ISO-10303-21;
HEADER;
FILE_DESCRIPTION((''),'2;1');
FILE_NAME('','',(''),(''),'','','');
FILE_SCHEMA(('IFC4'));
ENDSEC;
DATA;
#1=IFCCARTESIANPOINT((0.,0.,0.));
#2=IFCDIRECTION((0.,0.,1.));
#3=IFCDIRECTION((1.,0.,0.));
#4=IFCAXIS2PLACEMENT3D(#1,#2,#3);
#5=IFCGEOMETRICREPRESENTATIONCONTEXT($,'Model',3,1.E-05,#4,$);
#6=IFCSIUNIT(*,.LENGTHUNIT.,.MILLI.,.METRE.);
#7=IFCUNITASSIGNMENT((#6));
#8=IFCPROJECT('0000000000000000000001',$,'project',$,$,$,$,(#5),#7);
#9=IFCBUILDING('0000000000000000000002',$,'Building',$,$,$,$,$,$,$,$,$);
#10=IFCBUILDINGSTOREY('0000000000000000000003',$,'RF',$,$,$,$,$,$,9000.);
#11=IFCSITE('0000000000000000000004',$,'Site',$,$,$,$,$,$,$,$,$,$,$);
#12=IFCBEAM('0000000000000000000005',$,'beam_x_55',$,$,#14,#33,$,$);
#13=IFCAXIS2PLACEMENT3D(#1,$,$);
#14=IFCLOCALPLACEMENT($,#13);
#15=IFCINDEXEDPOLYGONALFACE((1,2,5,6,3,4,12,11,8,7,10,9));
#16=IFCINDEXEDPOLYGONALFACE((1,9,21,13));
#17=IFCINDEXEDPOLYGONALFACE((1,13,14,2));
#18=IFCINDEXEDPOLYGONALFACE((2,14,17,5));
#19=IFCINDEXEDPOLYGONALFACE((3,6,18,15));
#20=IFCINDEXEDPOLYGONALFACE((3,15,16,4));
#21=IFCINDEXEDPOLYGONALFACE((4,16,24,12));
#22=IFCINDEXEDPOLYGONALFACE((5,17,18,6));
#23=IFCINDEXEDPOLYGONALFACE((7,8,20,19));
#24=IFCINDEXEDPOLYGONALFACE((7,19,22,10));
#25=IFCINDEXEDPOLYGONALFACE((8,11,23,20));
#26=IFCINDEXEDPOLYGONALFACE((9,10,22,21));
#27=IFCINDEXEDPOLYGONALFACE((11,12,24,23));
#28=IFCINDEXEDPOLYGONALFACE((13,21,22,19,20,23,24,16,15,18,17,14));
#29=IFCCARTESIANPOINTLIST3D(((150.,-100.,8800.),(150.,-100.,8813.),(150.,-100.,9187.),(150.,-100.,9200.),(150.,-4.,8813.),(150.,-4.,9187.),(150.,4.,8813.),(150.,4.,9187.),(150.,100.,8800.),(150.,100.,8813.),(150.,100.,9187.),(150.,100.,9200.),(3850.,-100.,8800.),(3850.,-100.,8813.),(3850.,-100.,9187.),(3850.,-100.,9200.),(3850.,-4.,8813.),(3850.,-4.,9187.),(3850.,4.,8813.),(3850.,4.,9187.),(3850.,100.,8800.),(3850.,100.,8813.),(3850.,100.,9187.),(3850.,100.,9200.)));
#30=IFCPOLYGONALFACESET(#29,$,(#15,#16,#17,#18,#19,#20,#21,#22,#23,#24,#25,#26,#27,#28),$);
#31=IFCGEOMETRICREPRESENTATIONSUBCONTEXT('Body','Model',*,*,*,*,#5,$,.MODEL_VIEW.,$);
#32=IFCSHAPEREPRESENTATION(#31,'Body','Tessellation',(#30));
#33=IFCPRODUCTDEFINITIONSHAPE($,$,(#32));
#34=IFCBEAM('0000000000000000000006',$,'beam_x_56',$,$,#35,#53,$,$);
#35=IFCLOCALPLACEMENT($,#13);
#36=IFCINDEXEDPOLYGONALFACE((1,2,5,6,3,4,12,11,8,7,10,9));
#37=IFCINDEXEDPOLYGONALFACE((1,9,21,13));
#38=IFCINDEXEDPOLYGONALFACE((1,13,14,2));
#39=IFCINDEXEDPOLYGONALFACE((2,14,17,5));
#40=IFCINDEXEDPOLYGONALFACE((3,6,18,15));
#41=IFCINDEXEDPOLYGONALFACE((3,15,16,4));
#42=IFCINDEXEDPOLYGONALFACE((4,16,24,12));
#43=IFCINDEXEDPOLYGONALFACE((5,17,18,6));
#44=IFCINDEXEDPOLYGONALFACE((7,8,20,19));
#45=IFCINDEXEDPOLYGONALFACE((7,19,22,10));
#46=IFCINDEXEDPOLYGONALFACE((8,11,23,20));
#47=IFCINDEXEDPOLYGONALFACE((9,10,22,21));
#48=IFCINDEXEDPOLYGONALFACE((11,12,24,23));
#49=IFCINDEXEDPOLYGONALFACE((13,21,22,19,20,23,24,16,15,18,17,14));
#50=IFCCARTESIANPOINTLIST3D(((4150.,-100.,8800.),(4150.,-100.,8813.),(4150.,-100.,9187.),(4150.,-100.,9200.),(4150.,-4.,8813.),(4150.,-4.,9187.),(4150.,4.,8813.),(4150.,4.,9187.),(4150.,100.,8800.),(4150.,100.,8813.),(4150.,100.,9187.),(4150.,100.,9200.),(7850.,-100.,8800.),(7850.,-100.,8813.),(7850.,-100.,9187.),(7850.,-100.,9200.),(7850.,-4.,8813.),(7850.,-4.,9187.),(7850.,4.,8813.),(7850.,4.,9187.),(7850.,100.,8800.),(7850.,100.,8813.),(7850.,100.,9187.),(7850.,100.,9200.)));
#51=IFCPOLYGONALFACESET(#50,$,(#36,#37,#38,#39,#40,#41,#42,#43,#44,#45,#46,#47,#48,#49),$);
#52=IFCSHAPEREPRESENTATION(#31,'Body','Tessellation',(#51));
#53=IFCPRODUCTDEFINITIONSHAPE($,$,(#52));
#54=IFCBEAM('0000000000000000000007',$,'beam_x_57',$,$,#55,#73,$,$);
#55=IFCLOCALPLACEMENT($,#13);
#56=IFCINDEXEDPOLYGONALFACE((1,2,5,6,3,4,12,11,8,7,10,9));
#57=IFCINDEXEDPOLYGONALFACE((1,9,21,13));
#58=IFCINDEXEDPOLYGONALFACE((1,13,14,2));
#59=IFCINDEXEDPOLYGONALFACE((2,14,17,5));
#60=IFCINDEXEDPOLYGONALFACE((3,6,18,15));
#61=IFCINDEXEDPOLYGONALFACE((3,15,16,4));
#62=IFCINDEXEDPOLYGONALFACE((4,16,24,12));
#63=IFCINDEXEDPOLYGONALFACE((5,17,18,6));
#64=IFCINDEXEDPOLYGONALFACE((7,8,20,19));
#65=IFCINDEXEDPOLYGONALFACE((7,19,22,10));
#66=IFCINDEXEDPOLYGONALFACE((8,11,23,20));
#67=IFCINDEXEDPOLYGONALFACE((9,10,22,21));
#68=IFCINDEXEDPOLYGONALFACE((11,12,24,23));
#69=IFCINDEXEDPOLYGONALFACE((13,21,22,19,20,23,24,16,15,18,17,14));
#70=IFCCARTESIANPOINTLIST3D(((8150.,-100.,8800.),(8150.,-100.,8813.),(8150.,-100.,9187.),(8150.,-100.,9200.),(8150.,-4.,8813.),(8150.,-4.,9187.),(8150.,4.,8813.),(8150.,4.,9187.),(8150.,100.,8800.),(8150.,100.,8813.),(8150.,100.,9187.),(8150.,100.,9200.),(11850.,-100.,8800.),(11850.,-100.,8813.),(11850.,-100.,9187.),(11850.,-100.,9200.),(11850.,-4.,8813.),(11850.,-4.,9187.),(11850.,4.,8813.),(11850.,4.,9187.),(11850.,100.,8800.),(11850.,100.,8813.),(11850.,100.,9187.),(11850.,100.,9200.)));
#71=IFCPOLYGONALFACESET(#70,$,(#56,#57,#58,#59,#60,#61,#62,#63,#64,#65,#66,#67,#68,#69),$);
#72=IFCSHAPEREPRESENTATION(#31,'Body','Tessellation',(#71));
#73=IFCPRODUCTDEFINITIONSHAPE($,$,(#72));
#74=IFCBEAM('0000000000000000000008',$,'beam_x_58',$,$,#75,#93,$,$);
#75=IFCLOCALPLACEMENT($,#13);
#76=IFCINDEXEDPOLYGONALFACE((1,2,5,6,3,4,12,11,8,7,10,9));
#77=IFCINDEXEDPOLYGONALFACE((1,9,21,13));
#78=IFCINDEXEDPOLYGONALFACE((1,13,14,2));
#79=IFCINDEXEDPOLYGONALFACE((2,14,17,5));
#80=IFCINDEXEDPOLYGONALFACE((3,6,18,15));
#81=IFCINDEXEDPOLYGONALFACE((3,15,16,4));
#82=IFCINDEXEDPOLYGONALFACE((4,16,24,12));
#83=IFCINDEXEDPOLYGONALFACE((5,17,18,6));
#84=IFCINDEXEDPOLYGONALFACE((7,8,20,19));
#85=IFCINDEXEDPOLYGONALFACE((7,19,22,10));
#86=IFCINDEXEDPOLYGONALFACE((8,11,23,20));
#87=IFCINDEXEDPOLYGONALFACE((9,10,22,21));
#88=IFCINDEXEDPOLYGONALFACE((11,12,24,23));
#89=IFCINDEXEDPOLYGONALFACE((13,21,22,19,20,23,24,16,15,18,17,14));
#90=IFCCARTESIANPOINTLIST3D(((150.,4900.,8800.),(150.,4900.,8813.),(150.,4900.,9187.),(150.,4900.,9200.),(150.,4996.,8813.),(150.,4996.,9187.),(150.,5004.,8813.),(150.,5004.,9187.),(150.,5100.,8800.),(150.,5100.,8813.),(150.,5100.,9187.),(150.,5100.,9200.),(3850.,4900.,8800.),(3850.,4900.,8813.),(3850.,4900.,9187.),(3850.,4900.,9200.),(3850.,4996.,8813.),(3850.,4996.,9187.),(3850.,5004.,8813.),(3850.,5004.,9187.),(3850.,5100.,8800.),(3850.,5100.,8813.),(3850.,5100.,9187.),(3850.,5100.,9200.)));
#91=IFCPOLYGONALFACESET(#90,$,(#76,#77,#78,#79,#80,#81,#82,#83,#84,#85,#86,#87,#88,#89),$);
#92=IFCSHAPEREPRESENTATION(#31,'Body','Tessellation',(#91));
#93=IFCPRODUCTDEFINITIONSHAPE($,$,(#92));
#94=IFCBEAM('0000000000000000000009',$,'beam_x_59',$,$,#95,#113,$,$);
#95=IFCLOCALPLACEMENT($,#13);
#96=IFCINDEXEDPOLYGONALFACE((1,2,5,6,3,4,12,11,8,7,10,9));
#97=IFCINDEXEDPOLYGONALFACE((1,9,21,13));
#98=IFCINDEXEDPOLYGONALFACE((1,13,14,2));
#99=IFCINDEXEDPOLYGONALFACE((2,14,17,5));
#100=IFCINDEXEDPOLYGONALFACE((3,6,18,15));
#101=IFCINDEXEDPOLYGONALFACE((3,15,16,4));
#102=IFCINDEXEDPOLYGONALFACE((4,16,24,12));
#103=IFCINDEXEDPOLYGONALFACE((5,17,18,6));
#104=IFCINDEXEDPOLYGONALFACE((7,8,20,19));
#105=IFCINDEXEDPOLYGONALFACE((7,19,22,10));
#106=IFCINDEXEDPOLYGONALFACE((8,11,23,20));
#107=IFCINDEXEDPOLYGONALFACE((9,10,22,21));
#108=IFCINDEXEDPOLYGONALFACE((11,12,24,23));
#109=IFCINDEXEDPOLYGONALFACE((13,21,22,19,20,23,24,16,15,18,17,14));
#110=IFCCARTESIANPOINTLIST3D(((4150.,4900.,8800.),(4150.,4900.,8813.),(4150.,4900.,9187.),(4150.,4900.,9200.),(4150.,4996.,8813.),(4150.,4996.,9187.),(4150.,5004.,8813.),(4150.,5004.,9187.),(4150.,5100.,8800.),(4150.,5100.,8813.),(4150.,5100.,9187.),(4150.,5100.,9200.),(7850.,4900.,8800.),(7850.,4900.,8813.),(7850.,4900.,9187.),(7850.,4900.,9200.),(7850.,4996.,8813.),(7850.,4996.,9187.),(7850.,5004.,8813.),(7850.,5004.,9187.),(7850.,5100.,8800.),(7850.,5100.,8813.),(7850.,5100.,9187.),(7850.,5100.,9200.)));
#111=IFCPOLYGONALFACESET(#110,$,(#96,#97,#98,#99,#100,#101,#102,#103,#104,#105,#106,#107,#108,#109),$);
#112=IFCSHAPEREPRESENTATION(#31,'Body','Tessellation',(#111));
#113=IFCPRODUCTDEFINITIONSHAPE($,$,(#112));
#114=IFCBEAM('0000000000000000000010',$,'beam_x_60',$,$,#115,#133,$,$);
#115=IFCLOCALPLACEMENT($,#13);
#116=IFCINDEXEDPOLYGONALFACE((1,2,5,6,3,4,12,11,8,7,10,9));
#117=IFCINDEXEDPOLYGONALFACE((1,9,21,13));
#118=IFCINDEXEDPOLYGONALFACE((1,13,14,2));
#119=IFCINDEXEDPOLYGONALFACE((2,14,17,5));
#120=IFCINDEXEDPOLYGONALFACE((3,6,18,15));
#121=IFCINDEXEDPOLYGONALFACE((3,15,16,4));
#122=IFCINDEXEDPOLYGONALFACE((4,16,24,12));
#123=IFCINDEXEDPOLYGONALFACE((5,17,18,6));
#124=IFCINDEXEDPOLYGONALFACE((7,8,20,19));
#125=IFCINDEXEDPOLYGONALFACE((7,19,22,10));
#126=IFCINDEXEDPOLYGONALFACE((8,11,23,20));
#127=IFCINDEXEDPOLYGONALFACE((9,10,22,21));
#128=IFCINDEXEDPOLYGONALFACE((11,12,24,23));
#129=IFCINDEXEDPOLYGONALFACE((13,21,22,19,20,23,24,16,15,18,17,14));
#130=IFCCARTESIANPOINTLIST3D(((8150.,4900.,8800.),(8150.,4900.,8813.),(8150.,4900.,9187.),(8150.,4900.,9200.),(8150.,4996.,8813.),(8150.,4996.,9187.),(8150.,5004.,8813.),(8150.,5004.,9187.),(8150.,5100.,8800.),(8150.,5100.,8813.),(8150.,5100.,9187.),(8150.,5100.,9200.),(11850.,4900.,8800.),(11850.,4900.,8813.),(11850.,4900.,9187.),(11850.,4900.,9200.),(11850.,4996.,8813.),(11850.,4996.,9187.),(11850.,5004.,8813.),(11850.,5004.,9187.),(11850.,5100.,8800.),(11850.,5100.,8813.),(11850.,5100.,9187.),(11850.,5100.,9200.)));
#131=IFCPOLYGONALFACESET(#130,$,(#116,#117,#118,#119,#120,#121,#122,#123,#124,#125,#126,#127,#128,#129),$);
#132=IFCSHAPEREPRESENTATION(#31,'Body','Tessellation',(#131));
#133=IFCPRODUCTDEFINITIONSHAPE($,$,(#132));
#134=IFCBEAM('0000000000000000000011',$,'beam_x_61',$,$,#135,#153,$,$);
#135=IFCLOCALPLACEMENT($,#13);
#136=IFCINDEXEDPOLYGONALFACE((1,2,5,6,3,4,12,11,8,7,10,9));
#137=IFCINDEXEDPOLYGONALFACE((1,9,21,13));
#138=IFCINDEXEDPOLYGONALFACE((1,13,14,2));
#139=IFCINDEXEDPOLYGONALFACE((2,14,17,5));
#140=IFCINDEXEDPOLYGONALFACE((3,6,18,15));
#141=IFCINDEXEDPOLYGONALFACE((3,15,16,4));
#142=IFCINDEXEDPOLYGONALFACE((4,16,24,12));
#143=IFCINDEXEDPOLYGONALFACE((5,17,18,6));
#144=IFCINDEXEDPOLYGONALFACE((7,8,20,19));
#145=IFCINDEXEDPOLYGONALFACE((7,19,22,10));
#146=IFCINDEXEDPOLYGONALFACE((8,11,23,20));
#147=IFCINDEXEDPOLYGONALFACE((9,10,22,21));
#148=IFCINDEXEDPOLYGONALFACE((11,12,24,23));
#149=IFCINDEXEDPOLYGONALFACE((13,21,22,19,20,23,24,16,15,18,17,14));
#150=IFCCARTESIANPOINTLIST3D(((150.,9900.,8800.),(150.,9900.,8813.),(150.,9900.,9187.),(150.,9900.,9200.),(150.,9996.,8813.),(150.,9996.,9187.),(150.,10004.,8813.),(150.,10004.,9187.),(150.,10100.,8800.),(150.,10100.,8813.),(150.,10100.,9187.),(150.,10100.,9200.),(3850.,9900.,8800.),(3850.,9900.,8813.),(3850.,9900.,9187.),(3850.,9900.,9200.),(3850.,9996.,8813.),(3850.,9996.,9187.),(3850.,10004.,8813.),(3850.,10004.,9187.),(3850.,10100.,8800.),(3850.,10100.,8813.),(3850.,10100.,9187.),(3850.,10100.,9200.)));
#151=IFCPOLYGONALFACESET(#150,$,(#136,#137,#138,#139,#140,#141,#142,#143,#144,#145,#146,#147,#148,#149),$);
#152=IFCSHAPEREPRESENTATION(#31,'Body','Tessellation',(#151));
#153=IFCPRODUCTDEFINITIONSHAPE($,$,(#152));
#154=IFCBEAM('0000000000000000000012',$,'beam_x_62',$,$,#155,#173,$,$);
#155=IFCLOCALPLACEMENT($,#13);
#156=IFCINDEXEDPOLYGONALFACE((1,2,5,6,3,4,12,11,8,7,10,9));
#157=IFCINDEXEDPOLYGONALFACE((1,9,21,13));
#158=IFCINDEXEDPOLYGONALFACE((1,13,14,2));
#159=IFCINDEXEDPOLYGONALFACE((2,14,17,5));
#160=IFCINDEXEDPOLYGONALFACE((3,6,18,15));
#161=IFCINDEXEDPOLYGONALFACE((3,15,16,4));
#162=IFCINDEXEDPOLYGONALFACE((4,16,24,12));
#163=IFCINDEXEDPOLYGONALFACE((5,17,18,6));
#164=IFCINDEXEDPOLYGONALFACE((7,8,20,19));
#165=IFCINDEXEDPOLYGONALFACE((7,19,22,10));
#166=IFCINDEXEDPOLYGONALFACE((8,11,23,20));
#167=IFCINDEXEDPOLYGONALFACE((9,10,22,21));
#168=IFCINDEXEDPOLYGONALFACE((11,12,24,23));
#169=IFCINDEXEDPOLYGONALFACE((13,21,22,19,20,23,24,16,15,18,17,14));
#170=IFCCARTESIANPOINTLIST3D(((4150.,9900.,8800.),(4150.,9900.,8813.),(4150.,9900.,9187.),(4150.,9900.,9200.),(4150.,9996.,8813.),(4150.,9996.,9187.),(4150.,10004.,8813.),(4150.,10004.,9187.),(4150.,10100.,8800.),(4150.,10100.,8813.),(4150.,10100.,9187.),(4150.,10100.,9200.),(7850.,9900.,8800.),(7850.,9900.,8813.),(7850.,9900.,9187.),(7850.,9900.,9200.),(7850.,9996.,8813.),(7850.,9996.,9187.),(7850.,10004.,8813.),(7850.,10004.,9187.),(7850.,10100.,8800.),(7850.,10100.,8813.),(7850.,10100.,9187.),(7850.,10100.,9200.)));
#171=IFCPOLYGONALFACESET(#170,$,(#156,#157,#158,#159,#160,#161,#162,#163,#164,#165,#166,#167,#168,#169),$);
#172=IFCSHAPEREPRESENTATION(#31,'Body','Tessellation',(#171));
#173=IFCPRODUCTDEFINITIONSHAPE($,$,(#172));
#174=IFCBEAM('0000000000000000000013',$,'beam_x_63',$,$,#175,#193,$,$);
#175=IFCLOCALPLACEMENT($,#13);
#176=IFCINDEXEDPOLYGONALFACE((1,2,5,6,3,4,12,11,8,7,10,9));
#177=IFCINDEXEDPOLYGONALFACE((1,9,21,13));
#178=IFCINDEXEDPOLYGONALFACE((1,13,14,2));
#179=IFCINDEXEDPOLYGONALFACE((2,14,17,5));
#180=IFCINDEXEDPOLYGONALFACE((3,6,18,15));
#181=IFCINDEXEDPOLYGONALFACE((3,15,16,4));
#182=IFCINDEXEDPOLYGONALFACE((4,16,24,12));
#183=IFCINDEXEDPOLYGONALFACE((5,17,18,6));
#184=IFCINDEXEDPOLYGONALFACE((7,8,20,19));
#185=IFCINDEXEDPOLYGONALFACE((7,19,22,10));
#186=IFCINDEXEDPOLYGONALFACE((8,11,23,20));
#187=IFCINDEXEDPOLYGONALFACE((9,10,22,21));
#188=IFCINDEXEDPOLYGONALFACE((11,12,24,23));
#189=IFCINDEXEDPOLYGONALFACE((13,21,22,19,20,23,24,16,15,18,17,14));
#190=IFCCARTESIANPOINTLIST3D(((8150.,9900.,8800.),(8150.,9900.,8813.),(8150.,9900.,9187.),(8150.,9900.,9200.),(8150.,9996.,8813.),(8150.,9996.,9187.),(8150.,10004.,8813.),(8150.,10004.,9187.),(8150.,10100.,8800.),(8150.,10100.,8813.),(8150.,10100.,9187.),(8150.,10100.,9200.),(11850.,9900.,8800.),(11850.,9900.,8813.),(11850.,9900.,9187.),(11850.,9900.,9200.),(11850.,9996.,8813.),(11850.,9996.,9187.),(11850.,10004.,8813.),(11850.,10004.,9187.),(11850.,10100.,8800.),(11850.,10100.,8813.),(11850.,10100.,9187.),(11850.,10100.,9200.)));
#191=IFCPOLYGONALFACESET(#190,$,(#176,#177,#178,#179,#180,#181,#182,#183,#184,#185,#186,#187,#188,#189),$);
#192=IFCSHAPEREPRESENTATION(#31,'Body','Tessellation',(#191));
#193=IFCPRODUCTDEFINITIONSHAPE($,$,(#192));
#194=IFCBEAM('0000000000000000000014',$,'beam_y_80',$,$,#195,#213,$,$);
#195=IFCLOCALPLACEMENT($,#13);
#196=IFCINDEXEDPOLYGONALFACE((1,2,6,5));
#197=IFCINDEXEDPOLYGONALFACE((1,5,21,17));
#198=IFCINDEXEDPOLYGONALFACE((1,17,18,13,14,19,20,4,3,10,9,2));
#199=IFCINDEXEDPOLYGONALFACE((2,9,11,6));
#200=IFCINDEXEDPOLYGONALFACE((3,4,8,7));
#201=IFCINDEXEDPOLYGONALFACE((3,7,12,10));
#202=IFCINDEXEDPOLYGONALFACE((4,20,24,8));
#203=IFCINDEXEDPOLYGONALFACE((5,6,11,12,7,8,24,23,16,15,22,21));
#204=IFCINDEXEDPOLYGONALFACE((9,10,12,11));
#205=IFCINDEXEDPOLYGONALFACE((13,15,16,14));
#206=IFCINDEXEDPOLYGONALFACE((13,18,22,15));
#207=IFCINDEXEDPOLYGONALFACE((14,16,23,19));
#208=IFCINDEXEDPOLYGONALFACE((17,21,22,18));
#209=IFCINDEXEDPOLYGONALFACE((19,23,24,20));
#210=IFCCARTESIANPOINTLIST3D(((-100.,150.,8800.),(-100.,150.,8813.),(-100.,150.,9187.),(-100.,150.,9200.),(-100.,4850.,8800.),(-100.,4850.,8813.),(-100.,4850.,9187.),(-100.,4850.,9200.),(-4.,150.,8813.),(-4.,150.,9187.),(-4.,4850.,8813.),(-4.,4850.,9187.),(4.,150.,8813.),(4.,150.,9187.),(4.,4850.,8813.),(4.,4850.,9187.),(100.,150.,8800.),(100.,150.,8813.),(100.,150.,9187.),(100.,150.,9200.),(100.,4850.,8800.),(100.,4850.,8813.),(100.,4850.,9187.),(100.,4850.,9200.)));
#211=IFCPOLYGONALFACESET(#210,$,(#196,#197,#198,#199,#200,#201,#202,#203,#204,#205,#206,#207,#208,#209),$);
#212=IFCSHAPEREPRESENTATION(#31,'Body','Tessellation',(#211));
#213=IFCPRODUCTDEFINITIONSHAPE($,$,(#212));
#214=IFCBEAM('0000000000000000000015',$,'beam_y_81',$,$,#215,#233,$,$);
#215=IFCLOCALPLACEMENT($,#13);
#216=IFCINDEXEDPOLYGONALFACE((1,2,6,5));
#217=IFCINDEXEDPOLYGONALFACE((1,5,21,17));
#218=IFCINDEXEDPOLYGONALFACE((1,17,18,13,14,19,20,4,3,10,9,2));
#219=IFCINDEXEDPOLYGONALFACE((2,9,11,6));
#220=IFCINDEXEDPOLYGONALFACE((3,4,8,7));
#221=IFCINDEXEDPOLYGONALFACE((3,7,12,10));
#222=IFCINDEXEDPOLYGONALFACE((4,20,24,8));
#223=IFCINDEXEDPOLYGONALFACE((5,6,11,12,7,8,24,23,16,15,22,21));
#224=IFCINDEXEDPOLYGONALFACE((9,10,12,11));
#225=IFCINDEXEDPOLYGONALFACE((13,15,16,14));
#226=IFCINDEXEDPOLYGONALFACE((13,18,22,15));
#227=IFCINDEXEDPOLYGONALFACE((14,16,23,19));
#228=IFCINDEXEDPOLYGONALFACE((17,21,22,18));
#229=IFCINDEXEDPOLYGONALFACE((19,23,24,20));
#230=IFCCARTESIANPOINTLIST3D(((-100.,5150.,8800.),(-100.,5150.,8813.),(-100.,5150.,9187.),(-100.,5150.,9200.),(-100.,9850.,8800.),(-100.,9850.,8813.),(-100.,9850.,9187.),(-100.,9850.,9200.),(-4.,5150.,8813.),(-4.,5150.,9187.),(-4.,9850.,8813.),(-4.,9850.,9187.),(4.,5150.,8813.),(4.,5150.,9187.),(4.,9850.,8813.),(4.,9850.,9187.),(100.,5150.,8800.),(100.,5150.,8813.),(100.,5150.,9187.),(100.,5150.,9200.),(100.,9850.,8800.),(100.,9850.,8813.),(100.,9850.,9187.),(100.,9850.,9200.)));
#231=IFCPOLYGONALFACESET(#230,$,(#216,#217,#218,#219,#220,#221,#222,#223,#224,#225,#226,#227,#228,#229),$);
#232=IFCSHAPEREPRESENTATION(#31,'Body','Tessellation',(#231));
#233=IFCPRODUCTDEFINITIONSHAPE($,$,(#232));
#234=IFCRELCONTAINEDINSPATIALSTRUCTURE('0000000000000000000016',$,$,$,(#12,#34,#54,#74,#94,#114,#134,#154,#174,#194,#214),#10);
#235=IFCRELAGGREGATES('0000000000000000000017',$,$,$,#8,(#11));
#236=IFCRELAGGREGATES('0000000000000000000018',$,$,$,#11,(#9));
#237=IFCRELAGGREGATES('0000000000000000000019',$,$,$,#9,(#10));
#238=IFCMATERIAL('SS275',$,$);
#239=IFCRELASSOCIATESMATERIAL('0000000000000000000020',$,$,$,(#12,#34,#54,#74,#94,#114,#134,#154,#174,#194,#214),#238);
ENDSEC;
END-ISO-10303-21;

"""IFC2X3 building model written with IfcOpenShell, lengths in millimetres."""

from ifc_helpers import new_model, si_unit, frame, origin, origin_with_axes, origin_2d_with_axis, place, context, subcontext, project, spatial, i_section, extrude, material, element, save


model = new_model("IFC2X3")

# Units and contexts
model_context = context("Model", 3, precision=1e-05, world=origin_with_axes())
body_context = subcontext(model_context, "Body", "Model", "MODEL_VIEW")
ifc_project = project(units=[si_unit("LENGTHUNIT", "METRE", prefix="MILLI")], contexts=[model_context])

# Site, building, storey
site = spatial("IfcSite", under=ifc_project, Name="Site")
building = spatial("IfcBuilding", under=site, Name="Building")
storey = spatial("IfcBuildingStorey", under=building, Name="RF", Elevation=9000.0)

# Beams
ifc_material = material(Name="SS275")
for number, where, z_axis, x_axis, name in (
    (1, (150.0, 0.0, 9000.0), (1.0, 0.0, 0.0), (0.0, 1.0, 0.0), "beam_x_55"),
    (2, (4150.0, 0.0, 9000.0), (1.0, 0.0, 0.0), (0.0, 1.0, 0.0), "beam_x_56"),
    (3, (8150.0, 0.0, 9000.0), (1.0, 0.0, 0.0), (0.0, 1.0, 0.0), "beam_x_57"),
    (4, (150.0, 5000.0, 9000.0), (1.0, 0.0, 0.0), (0.0, 1.0, 0.0), "beam_x_58"),
    (5, (4150.0, 5000.0, 9000.0), (1.0, 0.0, 0.0), (0.0, 1.0, 0.0), "beam_x_59"),
    (6, (8150.0, 5000.0, 9000.0), (1.0, 0.0, 0.0), (0.0, 1.0, 0.0), "beam_x_60"),
    (7, (150.0, 10000.0, 9000.0), (1.0, 0.0, 0.0), (0.0, 1.0, 0.0), "beam_x_61"),
    (8, (4150.0, 10000.0, 9000.0), (1.0, 0.0, 0.0), (0.0, 1.0, 0.0), "beam_x_62"),
    (9, (8150.0, 10000.0, 9000.0), (1.0, 0.0, 0.0), (0.0, 1.0, 0.0), "beam_x_63"),
):
    element("IfcBeam", number, at=place(None, frame(where, z_axis=z_axis, x_axis=x_axis)), inside=storey, material=ifc_material, Name=name, context=body_context, shape_type="SweptSolid", body=[
        extrude(i_section(OverallWidth=200.0, OverallDepth=400.0, WebThickness=8.0, FlangeThickness=13.0, at=origin_2d_with_axis()), origin(), (0.0, 0.0, 1.0), 3700.0),
    ])
for number, where, z_axis, x_axis, name in (
    (10, (0.0, 150.0, 9000.0), (0.0, 1.0, 0.0), (-1.0, 0.0, 0.0), "beam_y_80"),
    (11, (0.0, 5150.0, 9000.0), (0.0, 1.0, 0.0), (-1.0, 0.0, 0.0), "beam_y_81"),
):
    element("IfcBeam", number, at=place(None, frame(where, z_axis=z_axis, x_axis=x_axis)), inside=storey, material=ifc_material, Name=name, context=body_context, shape_type="SweptSolid", body=[
        extrude(i_section(OverallWidth=200.0, OverallDepth=400.0, WebThickness=8.0, FlangeThickness=13.0, at=origin_2d_with_axis()), origin(), (0.0, 0.0, 1.0), 4700.0),
    ])

save(model, "model.ifc")
